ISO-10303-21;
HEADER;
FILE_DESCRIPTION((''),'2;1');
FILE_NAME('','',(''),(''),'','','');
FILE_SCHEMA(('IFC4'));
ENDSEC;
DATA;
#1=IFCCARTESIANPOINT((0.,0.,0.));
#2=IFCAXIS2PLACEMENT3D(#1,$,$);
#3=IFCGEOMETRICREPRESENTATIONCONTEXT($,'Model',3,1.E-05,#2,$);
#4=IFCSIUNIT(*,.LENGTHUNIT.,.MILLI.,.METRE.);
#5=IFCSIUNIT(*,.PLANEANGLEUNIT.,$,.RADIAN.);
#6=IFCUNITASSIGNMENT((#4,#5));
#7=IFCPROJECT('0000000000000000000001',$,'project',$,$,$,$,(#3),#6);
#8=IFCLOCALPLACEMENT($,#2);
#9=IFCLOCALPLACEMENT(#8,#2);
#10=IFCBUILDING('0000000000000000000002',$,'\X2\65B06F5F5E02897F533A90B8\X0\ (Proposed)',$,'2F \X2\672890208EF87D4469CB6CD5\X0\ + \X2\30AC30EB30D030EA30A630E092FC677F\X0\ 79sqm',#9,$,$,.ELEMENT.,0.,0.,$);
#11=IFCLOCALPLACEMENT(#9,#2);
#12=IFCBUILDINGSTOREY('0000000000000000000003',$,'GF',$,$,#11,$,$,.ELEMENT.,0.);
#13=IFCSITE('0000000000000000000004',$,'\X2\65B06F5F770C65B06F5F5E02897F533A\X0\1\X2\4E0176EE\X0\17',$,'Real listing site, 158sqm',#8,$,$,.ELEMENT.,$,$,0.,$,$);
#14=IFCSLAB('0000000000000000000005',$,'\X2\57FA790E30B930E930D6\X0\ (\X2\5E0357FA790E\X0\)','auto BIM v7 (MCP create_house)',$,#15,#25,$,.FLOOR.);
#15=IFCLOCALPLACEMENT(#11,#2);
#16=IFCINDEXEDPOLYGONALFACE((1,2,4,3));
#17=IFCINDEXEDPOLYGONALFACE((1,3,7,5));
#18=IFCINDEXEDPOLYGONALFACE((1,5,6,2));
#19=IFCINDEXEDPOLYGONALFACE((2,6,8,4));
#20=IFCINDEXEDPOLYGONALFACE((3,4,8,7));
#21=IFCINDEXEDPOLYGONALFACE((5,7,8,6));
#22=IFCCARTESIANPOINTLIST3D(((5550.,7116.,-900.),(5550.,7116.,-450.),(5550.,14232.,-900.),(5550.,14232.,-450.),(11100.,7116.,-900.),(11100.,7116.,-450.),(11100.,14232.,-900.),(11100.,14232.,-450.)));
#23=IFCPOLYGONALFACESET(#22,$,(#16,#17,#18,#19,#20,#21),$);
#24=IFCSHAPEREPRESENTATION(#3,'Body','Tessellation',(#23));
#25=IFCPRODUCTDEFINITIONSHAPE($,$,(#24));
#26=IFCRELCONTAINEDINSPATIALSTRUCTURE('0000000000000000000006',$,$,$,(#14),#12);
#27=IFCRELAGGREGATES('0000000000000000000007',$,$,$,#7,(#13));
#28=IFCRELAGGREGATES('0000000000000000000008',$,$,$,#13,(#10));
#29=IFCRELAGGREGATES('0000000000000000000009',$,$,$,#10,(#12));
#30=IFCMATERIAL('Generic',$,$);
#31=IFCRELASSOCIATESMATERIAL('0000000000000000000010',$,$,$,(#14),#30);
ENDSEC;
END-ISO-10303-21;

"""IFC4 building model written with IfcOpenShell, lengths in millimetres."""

from ifc_helpers import new_model, si_unit, frame, frame_2d, origin, place, context, project, spatial, rectangle, extrude, material, element, save


model = new_model("IFC4")

# Units and contexts
model_context = context("Model", 3, precision=1e-05, world=origin())
ifc_project = project(units=[si_unit("LENGTHUNIT", "METRE", prefix="MILLI"), si_unit("PLANEANGLEUNIT", "RADIAN")], contexts=[model_context])

# Site, building, storey
site_placement = place(None, origin())
site = spatial("IfcSite", under=ifc_project, at=site_placement, Name="新潟県新潟市西区1丁目17", ObjectType="Real listing site, 158sqm", CompositionType="ELEMENT", RefElevation=0.0)
building_placement = place(site_placement, origin())
building = spatial("IfcBuilding", under=site, at=building_placement, Name="新潟市西区邸 (Proposed)", ObjectType="2F 木造軸組構法 + ガルバリウム鋼板 79sqm", CompositionType="ELEMENT", ElevationOfRefHeight=0.0, ElevationOfTerrain=0.0)
storey_placement = place(building_placement, origin())
storey = spatial("IfcBuildingStorey", under=building, at=storey_placement, Name="GF", CompositionType="ELEMENT", Elevation=0.0)

# Slab
ifc_material = material(Name="Generic")
slab_1_placement = place(storey_placement, frame((2775.0, 3558.0, -450.0)))
element("IfcSlab", 1, at=slab_1_placement, inside=storey, material=ifc_material, Name="基礎スラブ (布基礎)", Description="auto BIM v7 (MCP create_house)", PredefinedType="FLOOR", context=model_context, shape_type="SweptSolid", body=[
    extrude(rectangle(XDim=5550.0, YDim=7116.0, at=frame_2d((2775.0, 3558.0))), frame((2775.0, 3558.0, -450.0)), (0.0, 0.0, 1.0), 450.0),
])

save(model, "model.ifc")
